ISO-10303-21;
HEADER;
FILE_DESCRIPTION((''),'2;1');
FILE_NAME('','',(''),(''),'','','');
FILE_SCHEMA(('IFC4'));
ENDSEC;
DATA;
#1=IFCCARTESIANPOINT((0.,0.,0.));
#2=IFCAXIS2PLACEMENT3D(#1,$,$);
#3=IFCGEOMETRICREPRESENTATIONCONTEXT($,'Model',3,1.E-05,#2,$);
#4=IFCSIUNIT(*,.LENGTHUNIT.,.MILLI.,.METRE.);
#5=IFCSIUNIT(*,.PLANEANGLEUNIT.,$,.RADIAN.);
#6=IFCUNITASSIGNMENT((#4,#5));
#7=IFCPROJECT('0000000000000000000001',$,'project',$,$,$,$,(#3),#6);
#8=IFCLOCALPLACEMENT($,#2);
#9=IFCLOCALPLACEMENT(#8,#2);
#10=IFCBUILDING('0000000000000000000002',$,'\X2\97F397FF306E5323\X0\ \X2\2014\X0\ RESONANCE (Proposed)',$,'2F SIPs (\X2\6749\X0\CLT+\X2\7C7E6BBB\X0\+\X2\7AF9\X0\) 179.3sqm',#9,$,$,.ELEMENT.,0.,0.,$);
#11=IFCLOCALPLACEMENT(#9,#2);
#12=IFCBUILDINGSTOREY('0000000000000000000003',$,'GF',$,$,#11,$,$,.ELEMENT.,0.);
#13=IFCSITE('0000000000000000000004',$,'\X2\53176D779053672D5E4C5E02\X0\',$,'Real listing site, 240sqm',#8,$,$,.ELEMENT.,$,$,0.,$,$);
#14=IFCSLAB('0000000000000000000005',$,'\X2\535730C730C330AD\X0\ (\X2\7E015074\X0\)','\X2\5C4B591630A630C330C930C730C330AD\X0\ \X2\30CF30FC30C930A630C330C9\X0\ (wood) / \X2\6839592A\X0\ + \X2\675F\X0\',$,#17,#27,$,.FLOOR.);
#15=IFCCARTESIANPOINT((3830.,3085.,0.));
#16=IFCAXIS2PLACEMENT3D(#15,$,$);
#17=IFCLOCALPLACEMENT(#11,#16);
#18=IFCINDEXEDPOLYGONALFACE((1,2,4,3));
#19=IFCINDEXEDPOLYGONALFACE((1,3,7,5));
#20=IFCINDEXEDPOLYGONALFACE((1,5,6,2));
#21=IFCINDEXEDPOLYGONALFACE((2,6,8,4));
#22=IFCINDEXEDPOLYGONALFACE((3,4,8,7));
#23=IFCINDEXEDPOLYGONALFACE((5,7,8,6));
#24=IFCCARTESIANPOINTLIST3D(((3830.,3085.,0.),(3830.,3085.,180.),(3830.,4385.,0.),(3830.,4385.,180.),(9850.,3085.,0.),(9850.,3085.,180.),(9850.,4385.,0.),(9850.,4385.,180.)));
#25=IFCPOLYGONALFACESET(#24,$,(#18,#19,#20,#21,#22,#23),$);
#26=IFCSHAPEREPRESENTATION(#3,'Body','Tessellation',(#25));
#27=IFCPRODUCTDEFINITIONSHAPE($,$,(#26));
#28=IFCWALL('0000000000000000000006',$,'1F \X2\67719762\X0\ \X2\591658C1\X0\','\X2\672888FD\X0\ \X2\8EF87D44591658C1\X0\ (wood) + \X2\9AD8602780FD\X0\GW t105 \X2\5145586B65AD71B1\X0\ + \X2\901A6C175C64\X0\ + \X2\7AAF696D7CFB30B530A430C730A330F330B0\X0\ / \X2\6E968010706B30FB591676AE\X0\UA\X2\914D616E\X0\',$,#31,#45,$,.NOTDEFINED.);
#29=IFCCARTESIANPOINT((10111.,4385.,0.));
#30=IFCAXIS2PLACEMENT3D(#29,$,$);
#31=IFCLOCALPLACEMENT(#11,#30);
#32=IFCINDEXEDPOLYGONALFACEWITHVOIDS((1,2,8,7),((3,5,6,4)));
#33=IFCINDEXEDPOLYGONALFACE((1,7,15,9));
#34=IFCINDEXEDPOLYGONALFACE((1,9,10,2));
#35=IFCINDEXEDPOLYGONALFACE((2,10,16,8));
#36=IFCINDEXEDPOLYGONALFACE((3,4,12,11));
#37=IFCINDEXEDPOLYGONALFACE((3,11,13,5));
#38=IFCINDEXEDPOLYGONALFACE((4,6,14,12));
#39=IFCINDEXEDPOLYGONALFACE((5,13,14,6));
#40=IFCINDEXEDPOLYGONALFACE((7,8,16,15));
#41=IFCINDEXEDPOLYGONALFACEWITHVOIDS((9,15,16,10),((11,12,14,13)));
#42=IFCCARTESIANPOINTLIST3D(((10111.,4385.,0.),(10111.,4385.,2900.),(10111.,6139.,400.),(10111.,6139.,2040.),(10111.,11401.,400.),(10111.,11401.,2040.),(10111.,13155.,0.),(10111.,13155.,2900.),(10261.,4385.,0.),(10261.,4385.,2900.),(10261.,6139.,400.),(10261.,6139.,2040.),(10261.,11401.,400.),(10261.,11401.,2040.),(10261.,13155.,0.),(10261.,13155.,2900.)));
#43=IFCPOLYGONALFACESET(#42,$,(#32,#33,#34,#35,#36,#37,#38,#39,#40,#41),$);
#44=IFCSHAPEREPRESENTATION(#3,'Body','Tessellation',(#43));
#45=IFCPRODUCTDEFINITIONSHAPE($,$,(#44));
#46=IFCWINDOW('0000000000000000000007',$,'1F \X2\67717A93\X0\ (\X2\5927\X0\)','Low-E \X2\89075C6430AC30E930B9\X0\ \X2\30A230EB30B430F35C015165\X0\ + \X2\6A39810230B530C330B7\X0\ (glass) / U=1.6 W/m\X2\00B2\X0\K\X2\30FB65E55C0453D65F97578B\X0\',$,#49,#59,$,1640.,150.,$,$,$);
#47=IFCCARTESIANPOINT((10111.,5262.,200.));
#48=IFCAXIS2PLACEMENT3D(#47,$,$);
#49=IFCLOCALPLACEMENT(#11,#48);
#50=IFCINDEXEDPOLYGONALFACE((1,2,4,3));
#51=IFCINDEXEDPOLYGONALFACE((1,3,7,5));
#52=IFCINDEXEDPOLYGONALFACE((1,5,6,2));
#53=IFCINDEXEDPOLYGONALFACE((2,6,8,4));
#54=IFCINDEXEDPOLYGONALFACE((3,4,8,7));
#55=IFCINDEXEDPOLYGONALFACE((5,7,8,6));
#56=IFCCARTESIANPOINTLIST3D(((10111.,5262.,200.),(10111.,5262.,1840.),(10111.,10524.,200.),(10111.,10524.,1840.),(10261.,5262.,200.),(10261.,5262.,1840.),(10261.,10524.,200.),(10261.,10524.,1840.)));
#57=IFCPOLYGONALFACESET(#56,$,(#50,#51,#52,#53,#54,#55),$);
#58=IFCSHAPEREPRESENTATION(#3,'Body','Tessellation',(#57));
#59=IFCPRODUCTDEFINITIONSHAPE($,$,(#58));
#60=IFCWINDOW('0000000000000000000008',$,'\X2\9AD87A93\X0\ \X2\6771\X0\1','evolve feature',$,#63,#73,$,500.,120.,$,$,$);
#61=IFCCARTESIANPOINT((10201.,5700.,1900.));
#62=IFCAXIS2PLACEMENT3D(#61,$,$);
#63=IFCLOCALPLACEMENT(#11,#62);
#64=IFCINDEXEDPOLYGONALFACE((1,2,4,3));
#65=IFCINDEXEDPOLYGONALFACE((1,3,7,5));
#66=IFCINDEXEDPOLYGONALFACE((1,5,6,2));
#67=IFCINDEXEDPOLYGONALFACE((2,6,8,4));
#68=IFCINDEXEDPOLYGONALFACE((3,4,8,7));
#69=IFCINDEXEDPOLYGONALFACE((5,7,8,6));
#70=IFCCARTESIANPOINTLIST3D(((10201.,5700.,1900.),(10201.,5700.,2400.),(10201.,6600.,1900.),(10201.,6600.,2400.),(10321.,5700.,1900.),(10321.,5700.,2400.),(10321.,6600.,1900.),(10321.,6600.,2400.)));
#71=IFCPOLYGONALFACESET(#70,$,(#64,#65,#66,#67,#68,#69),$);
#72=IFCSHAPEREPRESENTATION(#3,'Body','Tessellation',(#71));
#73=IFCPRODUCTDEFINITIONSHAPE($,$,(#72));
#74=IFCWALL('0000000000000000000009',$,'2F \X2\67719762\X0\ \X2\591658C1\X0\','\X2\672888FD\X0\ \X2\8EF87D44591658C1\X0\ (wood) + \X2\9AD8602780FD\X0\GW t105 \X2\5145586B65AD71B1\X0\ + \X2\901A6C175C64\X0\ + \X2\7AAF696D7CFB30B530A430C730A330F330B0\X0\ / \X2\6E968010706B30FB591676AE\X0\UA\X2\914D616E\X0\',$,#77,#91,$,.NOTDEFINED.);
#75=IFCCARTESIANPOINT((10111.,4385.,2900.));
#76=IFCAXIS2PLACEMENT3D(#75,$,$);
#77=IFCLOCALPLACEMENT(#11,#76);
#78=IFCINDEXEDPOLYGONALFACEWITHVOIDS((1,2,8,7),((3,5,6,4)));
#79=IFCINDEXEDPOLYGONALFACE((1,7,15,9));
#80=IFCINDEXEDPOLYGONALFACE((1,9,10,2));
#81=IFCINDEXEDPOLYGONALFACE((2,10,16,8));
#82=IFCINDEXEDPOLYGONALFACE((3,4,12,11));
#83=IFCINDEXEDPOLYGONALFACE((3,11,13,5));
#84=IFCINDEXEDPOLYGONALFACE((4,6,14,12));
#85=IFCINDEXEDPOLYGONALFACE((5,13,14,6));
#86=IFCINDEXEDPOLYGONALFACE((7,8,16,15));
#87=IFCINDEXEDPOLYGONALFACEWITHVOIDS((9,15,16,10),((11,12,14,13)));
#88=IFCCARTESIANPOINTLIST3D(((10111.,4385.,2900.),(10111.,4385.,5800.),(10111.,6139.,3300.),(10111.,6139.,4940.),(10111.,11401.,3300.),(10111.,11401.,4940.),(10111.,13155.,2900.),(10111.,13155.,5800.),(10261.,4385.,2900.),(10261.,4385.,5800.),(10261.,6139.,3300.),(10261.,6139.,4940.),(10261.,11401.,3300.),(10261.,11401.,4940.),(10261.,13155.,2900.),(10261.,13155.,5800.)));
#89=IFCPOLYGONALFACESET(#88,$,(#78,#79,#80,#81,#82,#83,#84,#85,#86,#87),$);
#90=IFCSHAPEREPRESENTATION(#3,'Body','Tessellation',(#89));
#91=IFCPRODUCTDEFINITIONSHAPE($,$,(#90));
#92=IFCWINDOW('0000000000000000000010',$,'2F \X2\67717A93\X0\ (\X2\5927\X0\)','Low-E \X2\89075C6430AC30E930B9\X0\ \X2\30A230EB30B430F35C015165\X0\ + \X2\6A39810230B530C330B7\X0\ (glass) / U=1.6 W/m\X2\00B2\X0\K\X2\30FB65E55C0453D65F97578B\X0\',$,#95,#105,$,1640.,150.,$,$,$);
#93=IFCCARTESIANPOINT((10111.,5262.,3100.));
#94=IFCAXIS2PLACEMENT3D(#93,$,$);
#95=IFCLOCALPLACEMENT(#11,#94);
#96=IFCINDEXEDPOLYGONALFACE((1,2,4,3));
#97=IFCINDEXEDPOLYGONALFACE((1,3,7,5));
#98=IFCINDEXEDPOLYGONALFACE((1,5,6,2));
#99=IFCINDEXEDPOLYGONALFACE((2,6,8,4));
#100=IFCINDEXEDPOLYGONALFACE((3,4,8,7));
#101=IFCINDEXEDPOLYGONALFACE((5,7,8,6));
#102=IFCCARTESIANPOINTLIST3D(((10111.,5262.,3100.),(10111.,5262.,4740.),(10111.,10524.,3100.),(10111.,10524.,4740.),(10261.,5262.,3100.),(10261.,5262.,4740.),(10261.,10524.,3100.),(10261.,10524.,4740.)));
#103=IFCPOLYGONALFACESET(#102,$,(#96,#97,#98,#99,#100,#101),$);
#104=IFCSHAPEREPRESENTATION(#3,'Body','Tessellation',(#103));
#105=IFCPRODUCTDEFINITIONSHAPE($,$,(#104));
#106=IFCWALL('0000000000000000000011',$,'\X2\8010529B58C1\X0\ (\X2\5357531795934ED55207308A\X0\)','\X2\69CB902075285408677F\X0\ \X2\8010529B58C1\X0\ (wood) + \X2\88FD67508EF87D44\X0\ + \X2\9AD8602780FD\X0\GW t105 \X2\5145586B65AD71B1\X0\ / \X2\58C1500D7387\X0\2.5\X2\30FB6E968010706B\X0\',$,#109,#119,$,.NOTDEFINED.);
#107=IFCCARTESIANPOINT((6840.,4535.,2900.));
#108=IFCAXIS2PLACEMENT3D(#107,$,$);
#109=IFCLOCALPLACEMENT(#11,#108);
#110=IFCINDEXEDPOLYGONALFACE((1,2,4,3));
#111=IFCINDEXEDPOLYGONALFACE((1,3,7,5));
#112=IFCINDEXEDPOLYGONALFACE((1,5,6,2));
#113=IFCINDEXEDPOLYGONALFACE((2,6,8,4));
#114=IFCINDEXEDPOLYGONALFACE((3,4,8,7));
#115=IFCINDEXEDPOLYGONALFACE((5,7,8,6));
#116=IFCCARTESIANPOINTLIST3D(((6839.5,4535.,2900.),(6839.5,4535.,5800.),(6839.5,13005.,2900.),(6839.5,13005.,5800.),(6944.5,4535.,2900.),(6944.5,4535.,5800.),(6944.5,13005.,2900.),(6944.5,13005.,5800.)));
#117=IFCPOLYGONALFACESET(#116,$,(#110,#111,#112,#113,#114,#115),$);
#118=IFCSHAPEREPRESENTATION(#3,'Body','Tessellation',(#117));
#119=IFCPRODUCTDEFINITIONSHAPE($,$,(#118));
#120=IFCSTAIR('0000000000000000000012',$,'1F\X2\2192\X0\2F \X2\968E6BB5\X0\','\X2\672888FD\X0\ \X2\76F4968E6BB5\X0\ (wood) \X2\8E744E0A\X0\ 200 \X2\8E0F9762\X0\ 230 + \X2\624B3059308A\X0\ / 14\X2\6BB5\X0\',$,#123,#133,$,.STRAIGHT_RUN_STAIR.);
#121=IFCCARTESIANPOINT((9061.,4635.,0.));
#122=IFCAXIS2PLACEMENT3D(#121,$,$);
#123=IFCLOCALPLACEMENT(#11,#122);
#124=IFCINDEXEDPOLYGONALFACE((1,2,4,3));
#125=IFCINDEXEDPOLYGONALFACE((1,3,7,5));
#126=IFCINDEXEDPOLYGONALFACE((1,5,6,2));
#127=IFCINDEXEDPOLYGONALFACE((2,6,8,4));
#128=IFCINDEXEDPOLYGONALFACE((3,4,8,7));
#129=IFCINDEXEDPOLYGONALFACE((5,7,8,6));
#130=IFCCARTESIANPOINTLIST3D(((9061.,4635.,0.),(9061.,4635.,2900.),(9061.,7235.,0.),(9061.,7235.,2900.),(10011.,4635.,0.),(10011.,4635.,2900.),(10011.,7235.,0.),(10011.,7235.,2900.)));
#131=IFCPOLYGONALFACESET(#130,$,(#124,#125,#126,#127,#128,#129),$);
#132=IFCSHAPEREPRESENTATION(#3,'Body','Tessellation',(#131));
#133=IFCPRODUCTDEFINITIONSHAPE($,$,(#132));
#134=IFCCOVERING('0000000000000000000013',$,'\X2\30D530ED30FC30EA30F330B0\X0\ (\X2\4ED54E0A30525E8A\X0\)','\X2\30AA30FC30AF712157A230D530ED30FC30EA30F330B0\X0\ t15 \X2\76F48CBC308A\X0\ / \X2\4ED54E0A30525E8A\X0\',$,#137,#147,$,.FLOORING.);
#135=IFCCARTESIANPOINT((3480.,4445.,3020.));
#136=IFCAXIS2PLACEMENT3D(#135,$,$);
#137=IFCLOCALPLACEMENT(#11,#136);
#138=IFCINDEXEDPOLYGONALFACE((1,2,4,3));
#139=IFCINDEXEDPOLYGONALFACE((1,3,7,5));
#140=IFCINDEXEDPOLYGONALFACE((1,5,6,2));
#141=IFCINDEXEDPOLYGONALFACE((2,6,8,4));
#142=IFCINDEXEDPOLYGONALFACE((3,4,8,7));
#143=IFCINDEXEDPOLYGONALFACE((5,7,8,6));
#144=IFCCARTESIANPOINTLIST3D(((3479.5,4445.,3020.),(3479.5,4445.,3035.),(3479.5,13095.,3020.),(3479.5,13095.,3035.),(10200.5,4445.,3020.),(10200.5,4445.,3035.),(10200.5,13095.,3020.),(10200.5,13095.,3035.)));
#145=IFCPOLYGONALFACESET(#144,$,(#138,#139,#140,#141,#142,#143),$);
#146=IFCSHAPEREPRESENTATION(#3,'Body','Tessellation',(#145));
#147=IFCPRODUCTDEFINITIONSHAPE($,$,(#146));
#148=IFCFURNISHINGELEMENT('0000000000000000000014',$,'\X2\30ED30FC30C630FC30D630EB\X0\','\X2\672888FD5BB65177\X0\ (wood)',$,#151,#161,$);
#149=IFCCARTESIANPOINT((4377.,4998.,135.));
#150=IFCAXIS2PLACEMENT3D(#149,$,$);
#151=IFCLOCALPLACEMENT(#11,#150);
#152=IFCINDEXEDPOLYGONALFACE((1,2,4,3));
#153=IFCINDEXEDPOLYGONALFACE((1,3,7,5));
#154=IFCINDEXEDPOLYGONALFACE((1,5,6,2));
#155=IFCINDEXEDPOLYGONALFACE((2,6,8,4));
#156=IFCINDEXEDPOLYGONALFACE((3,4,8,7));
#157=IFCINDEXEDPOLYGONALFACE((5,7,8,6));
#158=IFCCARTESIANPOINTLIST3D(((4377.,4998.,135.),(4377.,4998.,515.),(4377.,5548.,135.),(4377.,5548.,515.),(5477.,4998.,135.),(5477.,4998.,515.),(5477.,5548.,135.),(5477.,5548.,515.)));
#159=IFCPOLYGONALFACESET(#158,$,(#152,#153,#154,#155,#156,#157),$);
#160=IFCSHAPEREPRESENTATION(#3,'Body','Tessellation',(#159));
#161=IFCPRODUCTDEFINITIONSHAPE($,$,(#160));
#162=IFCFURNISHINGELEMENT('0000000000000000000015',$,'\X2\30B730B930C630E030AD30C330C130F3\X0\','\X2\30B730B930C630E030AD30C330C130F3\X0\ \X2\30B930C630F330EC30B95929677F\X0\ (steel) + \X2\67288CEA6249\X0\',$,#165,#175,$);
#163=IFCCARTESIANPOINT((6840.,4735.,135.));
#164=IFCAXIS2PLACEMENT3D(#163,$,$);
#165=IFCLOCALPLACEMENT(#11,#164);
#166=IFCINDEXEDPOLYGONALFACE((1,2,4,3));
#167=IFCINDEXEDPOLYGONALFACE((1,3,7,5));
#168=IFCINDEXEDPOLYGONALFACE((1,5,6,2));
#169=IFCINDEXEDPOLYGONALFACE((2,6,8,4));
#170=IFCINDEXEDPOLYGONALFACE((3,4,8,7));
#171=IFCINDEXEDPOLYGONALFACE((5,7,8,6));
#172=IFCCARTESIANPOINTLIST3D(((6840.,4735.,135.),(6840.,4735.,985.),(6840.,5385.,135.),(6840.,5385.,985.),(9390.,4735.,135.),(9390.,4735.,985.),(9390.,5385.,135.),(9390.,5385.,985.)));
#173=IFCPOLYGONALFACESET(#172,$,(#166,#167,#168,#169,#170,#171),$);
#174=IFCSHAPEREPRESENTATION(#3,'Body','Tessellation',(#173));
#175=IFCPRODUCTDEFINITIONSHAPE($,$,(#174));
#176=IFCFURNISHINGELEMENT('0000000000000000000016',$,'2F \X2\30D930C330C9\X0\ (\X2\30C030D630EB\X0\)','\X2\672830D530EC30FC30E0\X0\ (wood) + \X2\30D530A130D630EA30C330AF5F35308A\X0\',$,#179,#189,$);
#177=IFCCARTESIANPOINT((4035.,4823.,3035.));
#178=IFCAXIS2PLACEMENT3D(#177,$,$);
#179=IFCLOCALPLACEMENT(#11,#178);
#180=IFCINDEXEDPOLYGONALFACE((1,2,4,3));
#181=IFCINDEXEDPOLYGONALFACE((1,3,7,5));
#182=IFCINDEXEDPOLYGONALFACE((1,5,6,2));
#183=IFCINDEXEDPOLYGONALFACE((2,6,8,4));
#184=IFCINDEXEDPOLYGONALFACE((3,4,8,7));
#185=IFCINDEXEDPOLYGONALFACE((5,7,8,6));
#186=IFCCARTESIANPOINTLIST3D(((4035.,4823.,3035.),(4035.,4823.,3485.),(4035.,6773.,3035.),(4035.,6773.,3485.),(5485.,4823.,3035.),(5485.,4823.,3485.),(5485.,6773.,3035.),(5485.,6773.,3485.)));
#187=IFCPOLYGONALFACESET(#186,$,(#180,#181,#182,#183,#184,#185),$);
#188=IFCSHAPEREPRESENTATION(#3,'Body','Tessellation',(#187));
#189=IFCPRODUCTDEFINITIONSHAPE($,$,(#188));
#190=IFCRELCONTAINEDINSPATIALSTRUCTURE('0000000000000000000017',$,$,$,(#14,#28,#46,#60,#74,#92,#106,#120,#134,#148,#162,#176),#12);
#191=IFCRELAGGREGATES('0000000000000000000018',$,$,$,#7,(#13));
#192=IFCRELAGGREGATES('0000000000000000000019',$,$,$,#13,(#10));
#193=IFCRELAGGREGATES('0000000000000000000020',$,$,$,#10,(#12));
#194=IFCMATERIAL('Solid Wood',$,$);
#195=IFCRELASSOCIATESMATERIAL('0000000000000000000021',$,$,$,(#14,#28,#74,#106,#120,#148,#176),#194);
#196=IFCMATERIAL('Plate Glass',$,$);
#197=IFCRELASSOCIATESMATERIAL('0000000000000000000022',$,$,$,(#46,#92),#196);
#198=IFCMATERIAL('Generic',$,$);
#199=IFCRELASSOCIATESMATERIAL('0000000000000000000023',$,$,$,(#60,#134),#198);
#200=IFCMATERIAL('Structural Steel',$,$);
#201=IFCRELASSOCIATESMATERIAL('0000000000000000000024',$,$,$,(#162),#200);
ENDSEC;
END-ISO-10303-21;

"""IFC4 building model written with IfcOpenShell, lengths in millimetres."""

from ifc_helpers import new_model, si_unit, frame, frame_2d, origin, place, context, project, spatial, rectangle, extrude, material, element, fill, save


model = new_model("IFC4")

# Units and contexts
model_context = context("Model", 3, precision=1e-05, world=origin())
ifc_project = project(units=[si_unit("LENGTHUNIT", "METRE", prefix="MILLI"), si_unit("PLANEANGLEUNIT", "RADIAN")], contexts=[model_context])

# Site, building, storey
site_placement = place(None, origin())
site = spatial("IfcSite", under=ifc_project, at=site_placement, Name="北海道札幌市", ObjectType="Real listing site, 240sqm", CompositionType="ELEMENT", RefElevation=0.0)
building_placement = place(site_placement, origin())
building = spatial("IfcBuilding", under=site, at=building_placement, Name="音響の匣 — RESONANCE (Proposed)", ObjectType="2F SIPs (杉CLT+籾殻+竹) 179.3sqm", CompositionType="ELEMENT", ElevationOfRefHeight=0.0, ElevationOfTerrain=0.0)
storey_placement = place(building_placement, origin())
storey = spatial("IfcBuildingStorey", under=building, at=storey_placement, Name="GF", CompositionType="ELEMENT", Elevation=0.0)

# Slab
ifc_material_1 = material(Name="Solid Wood")
slab_placement = place(storey_placement, frame((3830.0, 3085.0, 0.0)))
element("IfcSlab", 1, at=slab_placement, inside=storey, material=ifc_material_1, Name="南デッキ (縁側)", Description="屋外ウッドデッキ ハードウッド (wood) / 根太 + 束", PredefinedType="FLOOR", context=model_context, shape_type="SweptSolid", body=[
    extrude(rectangle(XDim=6020.0, YDim=1300.0, at=frame_2d((3010.0, 650.0))), frame((3830.0, 3085.0, 0.0)), (0.0, 0.0, 1.0), 180.0),
])

# Wall, openings, windows
wall_1_placement = place(storey_placement, frame((10111.0, 4385.0, 0.0)))
wall_1 = element("IfcWall", 2, at=wall_1_placement, inside=storey, material=ifc_material_1, Name="1F 東面 外壁", Description="木製 軸組外壁 (wood) + 高性能GW t105 充填断熱 + 通気層 + 窯業系サイディング / 準耐火・外皮UA配慮", PredefinedType="NOTDEFINED", context=model_context, shape_type="SweptSolid", body=[
    extrude(rectangle(XDim=150.0, YDim=8770.0, at=frame_2d((75.0, 4385.0))), frame((10111.0, 4385.0, 0.0)), (0.0, 0.0, 1.0), 2900.0),
])
opening_1_placement = place(storey_placement, frame((10111.0, 5262.0, 200.0)))
opening_1 = element("IfcOpeningElement", 3, at=opening_1_placement, cuts=wall_1, PredefinedType="NOTDEFINED", context=model_context, shape_type="SweptSolid", body=[
    extrude(rectangle(XDim=150.0, YDim=5262.0, at=frame_2d((75.0, 2631.0))), frame((10111.0, 5262.0, 200.0)), (0.0, 0.0, 1.0), 1640.0),
])
opening_2_placement = place(storey_placement, frame((10201.0, 5700.0, 1900.0)))
opening_2 = element("IfcOpeningElement", 4, at=opening_2_placement, cuts=wall_1, PredefinedType="NOTDEFINED", context=model_context, shape_type="SweptSolid", body=[
    extrude(rectangle(XDim=120.0, YDim=900.0, at=frame_2d((60.0, 450.0))), frame((10201.0, 5700.0, 1900.0)), (0.0, 0.0, 1.0), 500.0),
])
ifc_material_2 = material(Name="Plate Glass")
window_1_placement = place(storey_placement, frame((10111.0, 5262.0, 200.0)))
window_1 = element("IfcWindow", 5, at=window_1_placement, inside=storey, material=ifc_material_2, Name="1F 東窓 (大)", Description="Low-E 複層ガラス アルゴン封入 + 樹脂サッシ (glass) / U=1.6 W/m²K・日射取得型", OverallHeight=1640.0, OverallWidth=150.0, context=model_context, shape_type="SweptSolid", body=[
    extrude(rectangle(XDim=150.0, YDim=5262.0, at=frame_2d((75.0, 2631.0))), frame((10111.0, 5262.0, 200.0)), (0.0, 0.0, 1.0), 1640.0),
])
fill(opening_1, window_1)
ifc_material_3 = material(Name="Generic")
window_2_placement = place(storey_placement, frame((10201.0, 5700.0, 1900.0)))
window_2 = element("IfcWindow", 6, at=window_2_placement, inside=storey, material=ifc_material_3, Name="高窓 東1", Description="evolve feature", OverallHeight=500.0, OverallWidth=120.0, context=model_context, shape_type="SweptSolid", body=[
    extrude(rectangle(XDim=120.0, YDim=900.0, at=frame_2d((60.0, 450.0))), frame((10201.0, 5700.0, 1900.0)), (0.0, 0.0, 1.0), 500.0),
])
fill(opening_2, window_2)

# Wall, opening, window
wall_2_placement = place(storey_placement, frame((10111.0, 4385.0, 2900.0)))
wall_2 = element("IfcWall", 7, at=wall_2_placement, inside=storey, material=ifc_material_1, Name="2F 東面 外壁", Description="木製 軸組外壁 (wood) + 高性能GW t105 充填断熱 + 通気層 + 窯業系サイディング / 準耐火・外皮UA配慮", PredefinedType="NOTDEFINED", context=model_context, shape_type="SweptSolid", body=[
    extrude(rectangle(XDim=150.0, YDim=8770.0, at=frame_2d((75.0, 4385.0))), frame((10111.0, 4385.0, 2900.0)), (0.0, 0.0, 1.0), 2900.0),
])
opening_3_placement = place(storey_placement, frame((10111.0, 5262.0, 3100.0)))
opening_3 = element("IfcOpeningElement", 8, at=opening_3_placement, cuts=wall_2, PredefinedType="NOTDEFINED", context=model_context, shape_type="SweptSolid", body=[
    extrude(rectangle(XDim=150.0, YDim=5262.0, at=frame_2d((75.0, 2631.0))), frame((10111.0, 5262.0, 3100.0)), (0.0, 0.0, 1.0), 1640.0),
])
window_3_placement = place(storey_placement, frame((10111.0, 5262.0, 3100.0)))
window_3 = element("IfcWindow", 9, at=window_3_placement, inside=storey, material=ifc_material_2, Name="2F 東窓 (大)", Description="Low-E 複層ガラス アルゴン封入 + 樹脂サッシ (glass) / U=1.6 W/m²K・日射取得型", OverallHeight=1640.0, OverallWidth=150.0, context=model_context, shape_type="SweptSolid", body=[
    extrude(rectangle(XDim=150.0, YDim=5262.0, at=frame_2d((75.0, 2631.0))), frame((10111.0, 5262.0, 3100.0)), (0.0, 0.0, 1.0), 1640.0),
])
fill(opening_3, window_3)

# Wall
wall_3_placement = place(storey_placement, frame((6840.0, 4535.0, 2900.0)))
element("IfcWall", 10, at=wall_3_placement, inside=storey, material=ifc_material_1, Name="耐力壁 (南北間仕切り)", Description="構造用合板 耐力壁 (wood) + 製材軸組 + 高性能GW t105 充填断熱 / 壁倍率2.5・準耐火", PredefinedType="NOTDEFINED", context=model_context, shape_type="SweptSolid", body=[
    extrude(rectangle(XDim=105.0, YDim=8470.0, at=frame_2d((52.0, 4235.0))), frame((6840.0, 4535.0, 2900.0)), (0.0, 0.0, 1.0), 2900.0),
])

# Stair
stair_placement = place(storey_placement, frame((9061.0, 4635.0, 0.0)))
element("IfcStair", 11, at=stair_placement, inside=storey, material=ifc_material_1, Name="1F→2F 階段", Description="木製 直階段 (wood) 蹴上 200 踏面 230 + 手すり / 14段", PredefinedType="STRAIGHT_RUN_STAIR", context=model_context, shape_type="SweptSolid", body=[
    extrude(rectangle(XDim=950.0, YDim=2600.0, at=frame_2d((475.0, 1300.0))), frame((9061.0, 4635.0, 0.0)), (0.0, 0.0, 1.0), 2900.0),
])

# Covering
covering_placement = place(storey_placement, frame((3480.0, 4445.0, 3020.0)))
element("IfcCovering", 12, at=covering_placement, inside=storey, material=ifc_material_3, Name="フローリング (仕上げ床)", Description="オーク無垢フローリング t15 直貼り / 仕上げ床", PredefinedType="FLOORING", context=model_context, shape_type="SweptSolid", body=[
    extrude(rectangle(XDim=6721.0, YDim=8650.0, at=frame_2d((3360.0, 4325.0))), frame((3480.0, 4445.0, 3020.0)), (0.0, 0.0, 1.0), 15.0),
])

# Furnishing elements
furnishing_1_placement = place(storey_placement, frame((4377.0, 4998.0, 135.0)))
element("IfcFurnishingElement", 13, at=furnishing_1_placement, inside=storey, material=ifc_material_1, Name="ローテーブル", Description="木製家具 (wood)", context=model_context, shape_type="SweptSolid", body=[
    extrude(rectangle(XDim=1100.0, YDim=550.0, at=frame_2d((550.0, 275.0))), frame((4377.0, 4998.0, 135.0)), (0.0, 0.0, 1.0), 380.0),
])
ifc_material_4 = material(Name="Structural Steel")
furnishing_2_placement = place(storey_placement, frame((6840.0, 4735.0, 135.0)))
element("IfcFurnishingElement", 14, at=furnishing_2_placement, inside=storey, material=ifc_material_4, Name="システムキッチン", Description="システムキッチン ステンレス天板 (steel) + 木質扉", context=model_context, shape_type="SweptSolid", body=[
    extrude(rectangle(XDim=2550.0, YDim=650.0, at=frame_2d((1275.0, 325.0))), frame((6840.0, 4735.0, 135.0)), (0.0, 0.0, 1.0), 850.0),
])
furnishing_3_placement = place(storey_placement, frame((4035.0, 4823.0, 3035.0)))
element("IfcFurnishingElement", 15, at=furnishing_3_placement, inside=storey, material=ifc_material_1, Name="2F ベッド (ダブル)", Description="木フレーム (wood) + ファブリック張り", context=model_context, shape_type="SweptSolid", body=[
    extrude(rectangle(XDim=1450.0, YDim=1950.0, at=frame_2d((725.0, 975.0))), frame((4035.0, 4823.0, 3035.0)), (0.0, 0.0, 1.0), 450.0),
])

save(model, "model.ifc")
